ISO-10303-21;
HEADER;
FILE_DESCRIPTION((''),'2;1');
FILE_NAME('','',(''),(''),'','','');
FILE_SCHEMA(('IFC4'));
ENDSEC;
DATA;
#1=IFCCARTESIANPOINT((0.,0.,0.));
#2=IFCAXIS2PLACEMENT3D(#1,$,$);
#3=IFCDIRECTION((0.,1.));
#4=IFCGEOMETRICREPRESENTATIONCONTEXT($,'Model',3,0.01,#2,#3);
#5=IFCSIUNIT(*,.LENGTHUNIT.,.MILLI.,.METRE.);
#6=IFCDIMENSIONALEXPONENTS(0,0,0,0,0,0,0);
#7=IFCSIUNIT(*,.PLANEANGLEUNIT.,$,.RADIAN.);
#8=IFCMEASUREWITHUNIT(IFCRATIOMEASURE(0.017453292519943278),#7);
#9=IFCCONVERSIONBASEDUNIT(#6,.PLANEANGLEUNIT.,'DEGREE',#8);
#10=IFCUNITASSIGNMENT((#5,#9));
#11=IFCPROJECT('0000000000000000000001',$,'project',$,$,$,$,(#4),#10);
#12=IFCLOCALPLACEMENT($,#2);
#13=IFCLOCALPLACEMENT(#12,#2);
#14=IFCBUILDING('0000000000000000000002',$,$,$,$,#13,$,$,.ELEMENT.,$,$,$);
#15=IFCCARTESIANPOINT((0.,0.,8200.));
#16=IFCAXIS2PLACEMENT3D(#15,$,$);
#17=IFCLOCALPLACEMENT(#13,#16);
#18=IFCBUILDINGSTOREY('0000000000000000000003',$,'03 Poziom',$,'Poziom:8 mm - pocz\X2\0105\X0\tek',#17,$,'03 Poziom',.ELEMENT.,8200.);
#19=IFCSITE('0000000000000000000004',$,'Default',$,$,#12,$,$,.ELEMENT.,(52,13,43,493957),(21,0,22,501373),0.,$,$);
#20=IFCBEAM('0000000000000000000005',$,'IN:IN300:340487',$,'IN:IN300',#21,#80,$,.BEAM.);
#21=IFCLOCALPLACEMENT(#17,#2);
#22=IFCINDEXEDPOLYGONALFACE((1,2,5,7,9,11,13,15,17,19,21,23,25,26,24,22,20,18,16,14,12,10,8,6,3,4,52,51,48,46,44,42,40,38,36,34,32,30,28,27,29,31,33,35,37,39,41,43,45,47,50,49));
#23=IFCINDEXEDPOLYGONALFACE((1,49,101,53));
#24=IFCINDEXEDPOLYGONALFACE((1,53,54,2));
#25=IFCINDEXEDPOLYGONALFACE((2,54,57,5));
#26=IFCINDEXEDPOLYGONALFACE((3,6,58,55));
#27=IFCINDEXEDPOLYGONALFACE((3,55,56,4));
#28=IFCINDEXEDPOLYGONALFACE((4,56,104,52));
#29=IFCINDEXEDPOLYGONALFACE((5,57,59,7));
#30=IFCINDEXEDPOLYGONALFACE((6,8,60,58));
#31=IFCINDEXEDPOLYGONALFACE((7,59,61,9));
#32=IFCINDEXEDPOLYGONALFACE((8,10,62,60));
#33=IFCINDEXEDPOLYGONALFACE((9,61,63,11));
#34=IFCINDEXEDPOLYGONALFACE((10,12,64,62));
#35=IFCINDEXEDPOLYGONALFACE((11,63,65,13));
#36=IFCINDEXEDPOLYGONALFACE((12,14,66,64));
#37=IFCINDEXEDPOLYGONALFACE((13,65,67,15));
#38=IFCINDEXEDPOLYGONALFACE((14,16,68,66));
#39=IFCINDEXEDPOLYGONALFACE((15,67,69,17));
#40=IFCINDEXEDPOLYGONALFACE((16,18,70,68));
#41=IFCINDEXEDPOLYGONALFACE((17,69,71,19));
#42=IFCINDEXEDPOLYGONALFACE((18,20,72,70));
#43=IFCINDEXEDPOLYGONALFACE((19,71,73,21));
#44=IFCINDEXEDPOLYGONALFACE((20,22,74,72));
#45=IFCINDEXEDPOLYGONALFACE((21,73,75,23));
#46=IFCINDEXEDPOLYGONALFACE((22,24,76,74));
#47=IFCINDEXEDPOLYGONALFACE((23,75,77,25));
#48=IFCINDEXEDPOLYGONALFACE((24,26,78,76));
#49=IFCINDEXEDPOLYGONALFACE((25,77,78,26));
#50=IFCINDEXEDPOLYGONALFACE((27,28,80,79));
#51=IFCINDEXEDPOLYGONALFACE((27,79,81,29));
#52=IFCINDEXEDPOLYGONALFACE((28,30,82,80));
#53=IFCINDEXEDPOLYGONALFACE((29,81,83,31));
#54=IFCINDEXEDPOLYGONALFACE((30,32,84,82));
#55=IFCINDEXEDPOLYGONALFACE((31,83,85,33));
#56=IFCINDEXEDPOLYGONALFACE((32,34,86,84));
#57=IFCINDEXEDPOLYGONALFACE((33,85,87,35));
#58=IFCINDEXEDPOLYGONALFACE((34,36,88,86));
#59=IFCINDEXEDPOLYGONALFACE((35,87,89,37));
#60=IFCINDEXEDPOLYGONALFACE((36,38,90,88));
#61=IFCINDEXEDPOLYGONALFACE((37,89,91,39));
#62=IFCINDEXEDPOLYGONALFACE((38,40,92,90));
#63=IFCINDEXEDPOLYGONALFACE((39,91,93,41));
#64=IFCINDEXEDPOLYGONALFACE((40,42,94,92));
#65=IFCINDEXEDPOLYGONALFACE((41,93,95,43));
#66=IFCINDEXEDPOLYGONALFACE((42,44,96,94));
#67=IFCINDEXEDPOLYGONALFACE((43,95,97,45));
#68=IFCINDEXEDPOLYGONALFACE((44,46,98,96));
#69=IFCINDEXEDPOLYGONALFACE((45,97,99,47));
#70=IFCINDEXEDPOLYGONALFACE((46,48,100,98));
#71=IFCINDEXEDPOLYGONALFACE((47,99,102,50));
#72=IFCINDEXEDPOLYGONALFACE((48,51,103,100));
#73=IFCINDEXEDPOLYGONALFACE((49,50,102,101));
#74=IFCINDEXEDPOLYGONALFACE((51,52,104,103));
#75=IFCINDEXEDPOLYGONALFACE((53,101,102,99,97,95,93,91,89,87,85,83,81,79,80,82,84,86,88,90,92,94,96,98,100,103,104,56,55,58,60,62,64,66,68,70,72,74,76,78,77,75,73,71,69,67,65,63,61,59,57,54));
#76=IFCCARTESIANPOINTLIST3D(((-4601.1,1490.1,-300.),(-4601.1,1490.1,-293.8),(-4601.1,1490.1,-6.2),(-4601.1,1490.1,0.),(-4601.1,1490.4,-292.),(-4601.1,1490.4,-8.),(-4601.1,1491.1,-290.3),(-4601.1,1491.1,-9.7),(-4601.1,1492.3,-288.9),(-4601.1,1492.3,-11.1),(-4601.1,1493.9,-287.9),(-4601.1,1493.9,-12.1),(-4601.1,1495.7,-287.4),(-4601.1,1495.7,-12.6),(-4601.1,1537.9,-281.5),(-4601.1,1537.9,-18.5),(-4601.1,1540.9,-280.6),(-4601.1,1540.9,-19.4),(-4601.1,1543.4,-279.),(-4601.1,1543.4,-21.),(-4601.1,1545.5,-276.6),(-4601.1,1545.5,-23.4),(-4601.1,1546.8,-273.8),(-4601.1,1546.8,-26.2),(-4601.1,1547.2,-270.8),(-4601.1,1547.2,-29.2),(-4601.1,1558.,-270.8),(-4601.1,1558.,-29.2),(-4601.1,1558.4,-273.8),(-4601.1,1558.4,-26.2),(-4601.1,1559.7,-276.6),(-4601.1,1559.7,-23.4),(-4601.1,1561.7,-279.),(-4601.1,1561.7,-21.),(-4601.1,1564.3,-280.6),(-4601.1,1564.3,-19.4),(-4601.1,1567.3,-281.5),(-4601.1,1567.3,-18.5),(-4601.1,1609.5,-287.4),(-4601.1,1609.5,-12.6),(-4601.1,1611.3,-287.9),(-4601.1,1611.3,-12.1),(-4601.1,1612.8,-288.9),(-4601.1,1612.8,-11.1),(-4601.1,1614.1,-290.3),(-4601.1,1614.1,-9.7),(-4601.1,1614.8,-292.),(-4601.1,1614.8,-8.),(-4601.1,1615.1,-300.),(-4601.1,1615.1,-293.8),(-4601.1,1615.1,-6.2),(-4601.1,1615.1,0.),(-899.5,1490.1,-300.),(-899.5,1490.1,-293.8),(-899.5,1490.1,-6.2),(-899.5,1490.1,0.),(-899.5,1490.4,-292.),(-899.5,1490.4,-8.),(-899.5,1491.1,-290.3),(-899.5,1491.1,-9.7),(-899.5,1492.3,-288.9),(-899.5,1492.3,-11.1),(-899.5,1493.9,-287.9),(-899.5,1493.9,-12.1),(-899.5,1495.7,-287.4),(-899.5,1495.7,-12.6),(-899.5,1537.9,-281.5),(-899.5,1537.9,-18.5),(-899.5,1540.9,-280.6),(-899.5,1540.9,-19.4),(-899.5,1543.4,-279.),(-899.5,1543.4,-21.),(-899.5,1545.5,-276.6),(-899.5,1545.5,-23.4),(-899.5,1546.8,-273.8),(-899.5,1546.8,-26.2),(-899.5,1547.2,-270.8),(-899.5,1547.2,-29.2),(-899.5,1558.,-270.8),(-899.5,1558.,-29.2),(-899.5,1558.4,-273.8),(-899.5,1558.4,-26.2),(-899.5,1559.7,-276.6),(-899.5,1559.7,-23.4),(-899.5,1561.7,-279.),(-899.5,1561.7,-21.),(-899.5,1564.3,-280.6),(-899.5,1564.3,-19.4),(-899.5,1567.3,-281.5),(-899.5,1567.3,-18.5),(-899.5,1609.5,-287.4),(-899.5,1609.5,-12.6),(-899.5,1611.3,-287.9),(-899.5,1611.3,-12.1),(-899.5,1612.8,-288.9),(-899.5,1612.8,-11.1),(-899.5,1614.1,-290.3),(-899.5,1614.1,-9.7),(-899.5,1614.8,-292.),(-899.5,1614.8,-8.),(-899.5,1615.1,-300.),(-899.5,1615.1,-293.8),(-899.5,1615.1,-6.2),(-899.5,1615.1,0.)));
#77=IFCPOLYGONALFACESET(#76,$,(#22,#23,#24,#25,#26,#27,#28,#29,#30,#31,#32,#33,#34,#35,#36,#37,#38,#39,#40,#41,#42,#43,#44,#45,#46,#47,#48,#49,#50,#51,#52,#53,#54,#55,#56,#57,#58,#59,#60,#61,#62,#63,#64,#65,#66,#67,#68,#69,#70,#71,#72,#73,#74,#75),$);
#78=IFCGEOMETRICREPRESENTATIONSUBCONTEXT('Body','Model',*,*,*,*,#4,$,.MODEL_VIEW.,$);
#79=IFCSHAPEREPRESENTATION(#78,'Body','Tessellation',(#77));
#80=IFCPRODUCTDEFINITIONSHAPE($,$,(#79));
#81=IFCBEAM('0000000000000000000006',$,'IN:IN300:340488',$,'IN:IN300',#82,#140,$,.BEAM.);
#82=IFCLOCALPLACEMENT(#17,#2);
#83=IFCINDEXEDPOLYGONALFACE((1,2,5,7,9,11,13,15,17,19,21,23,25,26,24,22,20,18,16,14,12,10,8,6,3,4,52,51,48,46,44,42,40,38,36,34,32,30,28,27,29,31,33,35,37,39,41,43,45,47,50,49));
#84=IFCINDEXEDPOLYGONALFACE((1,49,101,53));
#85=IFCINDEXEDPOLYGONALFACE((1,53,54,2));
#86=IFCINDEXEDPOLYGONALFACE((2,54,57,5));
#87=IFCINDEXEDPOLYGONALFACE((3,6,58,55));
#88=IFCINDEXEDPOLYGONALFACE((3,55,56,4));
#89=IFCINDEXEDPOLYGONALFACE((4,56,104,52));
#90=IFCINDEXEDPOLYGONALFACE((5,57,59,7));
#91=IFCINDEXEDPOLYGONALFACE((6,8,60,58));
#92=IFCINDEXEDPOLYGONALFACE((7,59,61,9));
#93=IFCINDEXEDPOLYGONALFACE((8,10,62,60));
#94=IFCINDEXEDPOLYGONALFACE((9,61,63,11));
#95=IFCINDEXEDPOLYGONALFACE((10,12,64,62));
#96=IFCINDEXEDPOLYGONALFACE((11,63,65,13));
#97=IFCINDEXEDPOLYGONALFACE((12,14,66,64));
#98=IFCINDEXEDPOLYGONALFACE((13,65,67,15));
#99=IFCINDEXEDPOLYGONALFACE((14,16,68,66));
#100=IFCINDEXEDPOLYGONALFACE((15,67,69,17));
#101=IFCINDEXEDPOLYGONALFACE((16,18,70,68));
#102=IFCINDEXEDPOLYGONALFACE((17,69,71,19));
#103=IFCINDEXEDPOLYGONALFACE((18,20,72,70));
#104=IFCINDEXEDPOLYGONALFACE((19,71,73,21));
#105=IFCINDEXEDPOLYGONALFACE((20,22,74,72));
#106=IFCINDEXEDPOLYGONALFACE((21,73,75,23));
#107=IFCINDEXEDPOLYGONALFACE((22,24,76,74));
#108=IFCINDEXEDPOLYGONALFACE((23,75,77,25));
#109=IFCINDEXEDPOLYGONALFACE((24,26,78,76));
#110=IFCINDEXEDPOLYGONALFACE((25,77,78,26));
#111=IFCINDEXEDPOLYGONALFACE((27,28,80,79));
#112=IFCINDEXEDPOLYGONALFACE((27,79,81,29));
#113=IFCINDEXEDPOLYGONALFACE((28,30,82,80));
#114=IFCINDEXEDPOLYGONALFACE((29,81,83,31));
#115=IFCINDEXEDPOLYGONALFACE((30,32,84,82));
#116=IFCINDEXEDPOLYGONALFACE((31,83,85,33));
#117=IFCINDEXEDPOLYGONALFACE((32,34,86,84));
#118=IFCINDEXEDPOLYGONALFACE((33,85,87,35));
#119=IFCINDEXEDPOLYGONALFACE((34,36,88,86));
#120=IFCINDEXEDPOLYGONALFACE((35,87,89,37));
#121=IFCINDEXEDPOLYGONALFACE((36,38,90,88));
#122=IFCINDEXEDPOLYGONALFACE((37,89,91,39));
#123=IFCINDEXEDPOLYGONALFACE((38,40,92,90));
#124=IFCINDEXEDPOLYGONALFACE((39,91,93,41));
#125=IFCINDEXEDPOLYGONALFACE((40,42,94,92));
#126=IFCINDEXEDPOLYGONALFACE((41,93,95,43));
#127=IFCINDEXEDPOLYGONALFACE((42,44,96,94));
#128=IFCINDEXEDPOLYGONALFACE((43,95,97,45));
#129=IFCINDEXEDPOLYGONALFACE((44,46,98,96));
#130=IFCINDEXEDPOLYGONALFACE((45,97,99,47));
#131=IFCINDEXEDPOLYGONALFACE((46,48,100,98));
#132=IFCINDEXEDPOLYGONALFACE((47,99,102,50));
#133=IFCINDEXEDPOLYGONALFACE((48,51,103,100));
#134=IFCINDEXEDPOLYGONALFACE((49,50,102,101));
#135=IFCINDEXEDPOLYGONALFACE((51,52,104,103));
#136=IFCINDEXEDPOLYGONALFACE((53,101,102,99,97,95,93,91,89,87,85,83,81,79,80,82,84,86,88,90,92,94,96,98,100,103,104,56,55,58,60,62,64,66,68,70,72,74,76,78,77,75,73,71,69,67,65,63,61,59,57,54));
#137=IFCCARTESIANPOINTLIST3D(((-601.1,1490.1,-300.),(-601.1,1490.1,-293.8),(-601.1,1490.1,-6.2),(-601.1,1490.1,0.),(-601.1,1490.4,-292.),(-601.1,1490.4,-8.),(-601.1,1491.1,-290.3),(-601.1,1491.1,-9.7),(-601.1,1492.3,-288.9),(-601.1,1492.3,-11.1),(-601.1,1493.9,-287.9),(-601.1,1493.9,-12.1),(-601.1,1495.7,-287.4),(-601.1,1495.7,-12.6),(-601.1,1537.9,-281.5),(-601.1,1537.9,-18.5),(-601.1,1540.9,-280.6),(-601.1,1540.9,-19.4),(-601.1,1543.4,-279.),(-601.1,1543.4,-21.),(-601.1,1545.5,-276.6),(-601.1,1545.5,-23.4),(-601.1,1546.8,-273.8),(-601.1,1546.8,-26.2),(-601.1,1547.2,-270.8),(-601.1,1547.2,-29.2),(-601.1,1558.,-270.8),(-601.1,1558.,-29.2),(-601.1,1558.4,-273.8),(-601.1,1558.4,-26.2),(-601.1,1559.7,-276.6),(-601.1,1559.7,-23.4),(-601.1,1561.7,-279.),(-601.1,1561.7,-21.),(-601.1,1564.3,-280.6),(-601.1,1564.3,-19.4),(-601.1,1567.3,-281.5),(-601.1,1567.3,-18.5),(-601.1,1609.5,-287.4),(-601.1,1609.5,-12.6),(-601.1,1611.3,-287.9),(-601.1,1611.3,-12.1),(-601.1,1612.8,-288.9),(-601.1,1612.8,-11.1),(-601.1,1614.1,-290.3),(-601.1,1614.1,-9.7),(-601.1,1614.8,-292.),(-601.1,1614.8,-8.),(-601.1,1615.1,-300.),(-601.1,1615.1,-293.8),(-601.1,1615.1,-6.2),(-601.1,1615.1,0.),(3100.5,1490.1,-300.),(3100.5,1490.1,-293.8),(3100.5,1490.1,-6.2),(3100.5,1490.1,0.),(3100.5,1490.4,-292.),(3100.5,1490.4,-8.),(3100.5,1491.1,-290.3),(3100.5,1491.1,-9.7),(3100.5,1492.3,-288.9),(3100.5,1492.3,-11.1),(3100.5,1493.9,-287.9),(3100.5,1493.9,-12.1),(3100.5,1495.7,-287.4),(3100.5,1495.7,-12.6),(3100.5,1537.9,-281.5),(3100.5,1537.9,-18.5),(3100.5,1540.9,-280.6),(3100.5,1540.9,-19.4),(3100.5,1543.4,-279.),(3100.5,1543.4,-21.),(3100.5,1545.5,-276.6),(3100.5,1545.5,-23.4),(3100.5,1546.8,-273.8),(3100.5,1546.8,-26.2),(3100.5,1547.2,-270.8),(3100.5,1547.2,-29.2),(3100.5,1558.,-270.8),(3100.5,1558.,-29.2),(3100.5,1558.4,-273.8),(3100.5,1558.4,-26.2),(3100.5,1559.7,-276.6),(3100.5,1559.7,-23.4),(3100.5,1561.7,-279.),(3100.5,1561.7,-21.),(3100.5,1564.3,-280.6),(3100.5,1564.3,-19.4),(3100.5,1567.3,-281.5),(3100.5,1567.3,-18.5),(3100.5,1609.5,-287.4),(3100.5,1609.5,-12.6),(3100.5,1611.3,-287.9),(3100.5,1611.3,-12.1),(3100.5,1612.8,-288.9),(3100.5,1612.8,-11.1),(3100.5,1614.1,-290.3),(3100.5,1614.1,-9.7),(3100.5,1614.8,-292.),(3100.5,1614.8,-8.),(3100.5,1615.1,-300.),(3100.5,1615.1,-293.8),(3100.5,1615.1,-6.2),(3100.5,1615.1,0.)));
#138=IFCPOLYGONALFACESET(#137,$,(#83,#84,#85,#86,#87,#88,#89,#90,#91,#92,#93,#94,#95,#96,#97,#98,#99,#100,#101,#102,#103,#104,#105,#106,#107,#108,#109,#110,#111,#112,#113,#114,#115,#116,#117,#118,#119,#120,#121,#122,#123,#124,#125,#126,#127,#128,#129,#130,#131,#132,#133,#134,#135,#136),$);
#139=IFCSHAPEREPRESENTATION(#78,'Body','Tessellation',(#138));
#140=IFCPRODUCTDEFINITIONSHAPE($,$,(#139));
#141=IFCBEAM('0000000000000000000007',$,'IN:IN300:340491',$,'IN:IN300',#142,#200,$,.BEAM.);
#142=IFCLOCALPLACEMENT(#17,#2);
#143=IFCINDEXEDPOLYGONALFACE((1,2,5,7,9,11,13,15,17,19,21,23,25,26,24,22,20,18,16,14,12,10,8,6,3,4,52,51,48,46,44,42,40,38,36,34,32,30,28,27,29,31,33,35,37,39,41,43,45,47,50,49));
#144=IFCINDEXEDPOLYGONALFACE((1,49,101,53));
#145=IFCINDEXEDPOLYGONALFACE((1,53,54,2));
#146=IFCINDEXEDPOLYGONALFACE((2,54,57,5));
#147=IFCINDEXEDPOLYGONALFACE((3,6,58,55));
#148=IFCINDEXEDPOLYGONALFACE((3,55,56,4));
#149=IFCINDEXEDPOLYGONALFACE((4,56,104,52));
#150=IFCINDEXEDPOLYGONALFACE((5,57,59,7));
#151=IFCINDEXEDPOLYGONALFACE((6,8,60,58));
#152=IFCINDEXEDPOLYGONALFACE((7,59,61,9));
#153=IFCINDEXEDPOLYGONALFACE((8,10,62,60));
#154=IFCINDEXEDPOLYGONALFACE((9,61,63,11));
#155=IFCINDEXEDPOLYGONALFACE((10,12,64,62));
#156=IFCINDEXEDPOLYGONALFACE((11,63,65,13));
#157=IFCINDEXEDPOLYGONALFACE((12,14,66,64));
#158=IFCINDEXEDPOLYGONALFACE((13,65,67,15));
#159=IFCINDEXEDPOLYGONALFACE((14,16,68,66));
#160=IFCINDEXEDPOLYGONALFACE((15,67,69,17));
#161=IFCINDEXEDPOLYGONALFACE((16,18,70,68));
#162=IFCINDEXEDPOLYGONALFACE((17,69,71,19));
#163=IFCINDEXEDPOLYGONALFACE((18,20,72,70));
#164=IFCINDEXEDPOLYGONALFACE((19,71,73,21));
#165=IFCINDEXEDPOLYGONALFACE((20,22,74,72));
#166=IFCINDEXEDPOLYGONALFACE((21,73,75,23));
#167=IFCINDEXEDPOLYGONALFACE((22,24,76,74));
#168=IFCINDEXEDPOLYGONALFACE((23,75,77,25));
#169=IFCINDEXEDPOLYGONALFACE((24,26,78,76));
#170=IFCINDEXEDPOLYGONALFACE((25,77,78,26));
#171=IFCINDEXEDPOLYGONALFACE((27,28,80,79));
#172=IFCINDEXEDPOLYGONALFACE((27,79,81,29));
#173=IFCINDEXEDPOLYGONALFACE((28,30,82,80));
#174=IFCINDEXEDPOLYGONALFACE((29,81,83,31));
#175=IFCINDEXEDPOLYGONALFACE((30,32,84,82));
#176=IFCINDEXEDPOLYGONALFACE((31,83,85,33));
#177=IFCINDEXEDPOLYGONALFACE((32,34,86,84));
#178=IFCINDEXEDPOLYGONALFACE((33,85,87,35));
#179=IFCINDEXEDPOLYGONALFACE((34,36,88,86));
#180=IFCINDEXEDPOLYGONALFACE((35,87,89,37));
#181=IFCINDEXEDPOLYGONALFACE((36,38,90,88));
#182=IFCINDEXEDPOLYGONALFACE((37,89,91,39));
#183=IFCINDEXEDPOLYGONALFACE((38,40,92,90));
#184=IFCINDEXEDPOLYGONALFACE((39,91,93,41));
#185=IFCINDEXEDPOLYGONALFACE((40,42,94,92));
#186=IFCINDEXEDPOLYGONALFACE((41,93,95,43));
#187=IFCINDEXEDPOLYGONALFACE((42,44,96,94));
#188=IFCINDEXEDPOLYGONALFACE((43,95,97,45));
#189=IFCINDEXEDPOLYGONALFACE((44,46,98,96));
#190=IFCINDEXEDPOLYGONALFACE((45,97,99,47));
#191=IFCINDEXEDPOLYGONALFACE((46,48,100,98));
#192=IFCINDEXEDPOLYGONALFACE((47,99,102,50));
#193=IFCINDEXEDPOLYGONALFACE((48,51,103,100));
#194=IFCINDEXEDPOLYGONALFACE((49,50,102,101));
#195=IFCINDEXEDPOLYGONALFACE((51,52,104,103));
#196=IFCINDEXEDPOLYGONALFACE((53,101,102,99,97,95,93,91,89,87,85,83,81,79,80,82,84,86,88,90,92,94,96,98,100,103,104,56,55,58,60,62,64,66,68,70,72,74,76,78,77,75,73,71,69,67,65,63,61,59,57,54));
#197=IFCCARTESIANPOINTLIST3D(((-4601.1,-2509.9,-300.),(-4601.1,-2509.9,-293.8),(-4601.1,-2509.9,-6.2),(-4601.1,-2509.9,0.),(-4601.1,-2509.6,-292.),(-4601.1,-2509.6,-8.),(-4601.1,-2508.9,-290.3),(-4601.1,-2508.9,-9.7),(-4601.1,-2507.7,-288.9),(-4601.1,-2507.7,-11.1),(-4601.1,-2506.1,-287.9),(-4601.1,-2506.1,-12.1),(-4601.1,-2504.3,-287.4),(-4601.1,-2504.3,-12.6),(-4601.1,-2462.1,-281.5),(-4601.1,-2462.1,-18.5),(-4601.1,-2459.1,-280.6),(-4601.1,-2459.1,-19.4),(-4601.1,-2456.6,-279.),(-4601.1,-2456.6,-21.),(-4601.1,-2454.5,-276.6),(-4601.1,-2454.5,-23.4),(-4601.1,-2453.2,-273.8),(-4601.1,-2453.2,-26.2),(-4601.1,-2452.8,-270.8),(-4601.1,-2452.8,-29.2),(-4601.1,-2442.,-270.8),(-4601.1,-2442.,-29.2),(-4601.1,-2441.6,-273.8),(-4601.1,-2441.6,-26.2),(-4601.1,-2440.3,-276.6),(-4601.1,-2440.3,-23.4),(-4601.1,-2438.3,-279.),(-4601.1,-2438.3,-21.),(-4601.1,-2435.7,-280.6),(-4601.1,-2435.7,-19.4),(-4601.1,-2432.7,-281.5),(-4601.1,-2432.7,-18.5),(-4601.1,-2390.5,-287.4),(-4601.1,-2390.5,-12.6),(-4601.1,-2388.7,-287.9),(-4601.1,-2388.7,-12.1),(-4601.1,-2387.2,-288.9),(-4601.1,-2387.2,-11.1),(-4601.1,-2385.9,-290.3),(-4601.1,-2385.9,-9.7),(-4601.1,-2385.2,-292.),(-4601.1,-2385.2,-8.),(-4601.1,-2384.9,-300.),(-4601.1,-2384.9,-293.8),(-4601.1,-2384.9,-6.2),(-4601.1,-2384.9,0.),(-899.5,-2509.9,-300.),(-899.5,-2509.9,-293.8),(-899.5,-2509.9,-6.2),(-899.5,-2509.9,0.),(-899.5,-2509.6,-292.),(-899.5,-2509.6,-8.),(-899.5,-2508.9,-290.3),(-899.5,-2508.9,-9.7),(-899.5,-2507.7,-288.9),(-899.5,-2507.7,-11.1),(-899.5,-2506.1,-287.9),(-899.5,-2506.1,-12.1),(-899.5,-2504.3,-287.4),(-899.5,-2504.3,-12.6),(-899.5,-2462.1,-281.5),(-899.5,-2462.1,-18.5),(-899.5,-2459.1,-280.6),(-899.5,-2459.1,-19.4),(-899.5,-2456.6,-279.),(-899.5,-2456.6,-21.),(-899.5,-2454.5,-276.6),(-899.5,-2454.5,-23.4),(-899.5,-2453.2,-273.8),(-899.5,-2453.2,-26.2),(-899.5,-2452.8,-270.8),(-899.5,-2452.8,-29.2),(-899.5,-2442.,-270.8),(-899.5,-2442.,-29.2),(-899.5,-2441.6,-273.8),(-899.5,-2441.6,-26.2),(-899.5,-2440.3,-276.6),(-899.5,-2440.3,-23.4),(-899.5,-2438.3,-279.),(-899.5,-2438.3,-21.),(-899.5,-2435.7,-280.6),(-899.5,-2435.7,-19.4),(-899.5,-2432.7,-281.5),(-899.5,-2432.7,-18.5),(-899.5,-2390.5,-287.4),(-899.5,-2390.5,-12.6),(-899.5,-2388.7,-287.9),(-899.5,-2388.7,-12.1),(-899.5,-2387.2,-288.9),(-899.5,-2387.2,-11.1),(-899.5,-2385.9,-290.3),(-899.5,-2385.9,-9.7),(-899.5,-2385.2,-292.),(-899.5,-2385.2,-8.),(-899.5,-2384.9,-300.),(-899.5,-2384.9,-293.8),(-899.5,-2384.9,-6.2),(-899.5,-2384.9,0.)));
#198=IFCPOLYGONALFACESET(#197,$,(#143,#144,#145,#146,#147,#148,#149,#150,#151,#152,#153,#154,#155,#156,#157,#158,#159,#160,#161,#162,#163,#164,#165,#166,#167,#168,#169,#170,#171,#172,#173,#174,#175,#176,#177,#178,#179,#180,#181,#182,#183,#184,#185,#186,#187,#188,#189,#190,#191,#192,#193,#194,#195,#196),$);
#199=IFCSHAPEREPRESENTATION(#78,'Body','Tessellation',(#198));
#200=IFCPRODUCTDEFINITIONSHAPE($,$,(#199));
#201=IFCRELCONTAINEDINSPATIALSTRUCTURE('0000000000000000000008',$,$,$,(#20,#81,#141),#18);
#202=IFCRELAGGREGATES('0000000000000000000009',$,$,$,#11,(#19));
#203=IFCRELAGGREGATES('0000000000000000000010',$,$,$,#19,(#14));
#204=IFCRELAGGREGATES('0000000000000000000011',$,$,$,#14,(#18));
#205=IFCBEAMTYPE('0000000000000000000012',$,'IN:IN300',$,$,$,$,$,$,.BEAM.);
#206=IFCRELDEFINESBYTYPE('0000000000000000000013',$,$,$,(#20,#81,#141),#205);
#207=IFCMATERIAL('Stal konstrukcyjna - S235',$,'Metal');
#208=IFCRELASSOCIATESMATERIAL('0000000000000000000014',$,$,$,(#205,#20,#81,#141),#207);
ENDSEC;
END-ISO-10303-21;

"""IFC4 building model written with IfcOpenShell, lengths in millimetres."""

from ifc_helpers import new_model, entity, si_unit, converted_unit, direction, frame, origin, place, context, subcontext, project, spatial, line, arc, indexed_curve, outline, extrude, source, transform, mapped, material, type_object, type_shapes, element, save


model = new_model("IFC4")

# Units and contexts
model_context = context("Model", 3, precision=0.01, world=origin(), true_north=direction((0.0, 1.0)))
body_context = subcontext(model_context, "Body", "Model", "MODEL_VIEW")
ifc_project = project(units=[si_unit("LENGTHUNIT", "METRE", prefix="MILLI"), converted_unit("PLANEANGLEUNIT", "DEGREE", entity("IfcRatioMeasure", 0.017453292519943278), si_unit("PLANEANGLEUNIT", "RADIAN"), dimensions=[0, 0, 0, 0, 0, 0, 0])], contexts=[model_context])

# Site, building, storey
site_placement = place(None, origin())
site = spatial("IfcSite", under=ifc_project, at=site_placement, Name="Default", CompositionType="ELEMENT", RefLatitude=(52, 13, 43, 493957), RefLongitude=(21, 0, 22, 501373), RefElevation=0.0)
building_placement = place(site_placement, origin())
building = spatial("IfcBuilding", under=site, at=building_placement, CompositionType="ELEMENT")
storey_placement = place(building_placement, frame((0.0, 0.0, 8200.0)))
storey = spatial("IfcBuildingStorey", under=building, at=storey_placement, Name="03 Poziom", ObjectType="Poziom:8 mm - początek", LongName="03 Poziom", CompositionType="ELEMENT", Elevation=8200.0)

# Shared definitions
ifc_material_1 = material(Name="Stal konstrukcyjna - S235", Category="Metal")

# Beams
beam_type_1 = type_object("IfcBeamType", Name="IN:IN300", PredefinedType="BEAM", material=ifc_material_1)
shared_shape_1 = source(origin(), body_context, "Body", "SweptSolid", [
    extrude(outline(indexed_curve([(143.8, -62.5), (150.0, -62.5), (150.0, 62.5), (143.8, 62.5), (139.6, 60.9), (137.4, 56.9), (131.5, 14.7), (127.9, 8.1), (120.8, 5.4), (-120.8, 5.4), (-127.9, 8.1), (-131.5, 14.7), (-137.4, 56.9), (-139.6, 60.9), (-143.8, 62.5), (-150.0, 62.5), (-150.0, -62.5), (-143.8, -62.5), (-139.6, -60.9), (-137.4, -56.9), (-131.5, -14.7), (-127.9, -8.1), (-120.8, -5.4), (120.8, -5.4), (127.9, -8.1), (131.5, -14.7), (137.4, -56.9), (139.6, -60.9)], segments=[line(1, 2, 3, 4), arc(4, 5, 6), line(6, 7), arc(7, 8, 9), line(9, 10), arc(10, 11, 12), line(12, 13), arc(13, 14, 15), line(15, 16, 17, 18), arc(18, 19, 20), line(20, 21), arc(21, 22, 23), line(23, 24), arc(24, 25, 26), line(26, 27), arc(27, 28, 1)], self_intersect=False)), frame((-1850.8, 0.0, 0.0), z_axis=(1.0, 0.0, 0.0), x_axis=(0.0, 0.0, -1.0)), (0.0, 0.0, 1.0), 3701.6),
])
type_shapes(beam_type_1, [shared_shape_1])
for number, where, name in (
    (1, (-2750.3, 1552.6, -150.0), "IN:IN300:340487"),
    (2, (1249.7, 1552.6, -150.0), "IN:IN300:340488"),
    (3, (-2750.3, -2447.4, -150.0), "IN:IN300:340491"),
):
    element("IfcBeam", number, at=place(storey_placement, frame(where)), inside=storey, type_object=beam_type_1, material=ifc_material_1, Name=name, ObjectType="IN:IN300", PredefinedType="BEAM", context=body_context, shape_type="MappedRepresentation", body=[
        mapped(shared_shape_1, transform((0.0, 0.0, 0.0), scale=1.0)),
    ])

save(model, "model.ifc")
